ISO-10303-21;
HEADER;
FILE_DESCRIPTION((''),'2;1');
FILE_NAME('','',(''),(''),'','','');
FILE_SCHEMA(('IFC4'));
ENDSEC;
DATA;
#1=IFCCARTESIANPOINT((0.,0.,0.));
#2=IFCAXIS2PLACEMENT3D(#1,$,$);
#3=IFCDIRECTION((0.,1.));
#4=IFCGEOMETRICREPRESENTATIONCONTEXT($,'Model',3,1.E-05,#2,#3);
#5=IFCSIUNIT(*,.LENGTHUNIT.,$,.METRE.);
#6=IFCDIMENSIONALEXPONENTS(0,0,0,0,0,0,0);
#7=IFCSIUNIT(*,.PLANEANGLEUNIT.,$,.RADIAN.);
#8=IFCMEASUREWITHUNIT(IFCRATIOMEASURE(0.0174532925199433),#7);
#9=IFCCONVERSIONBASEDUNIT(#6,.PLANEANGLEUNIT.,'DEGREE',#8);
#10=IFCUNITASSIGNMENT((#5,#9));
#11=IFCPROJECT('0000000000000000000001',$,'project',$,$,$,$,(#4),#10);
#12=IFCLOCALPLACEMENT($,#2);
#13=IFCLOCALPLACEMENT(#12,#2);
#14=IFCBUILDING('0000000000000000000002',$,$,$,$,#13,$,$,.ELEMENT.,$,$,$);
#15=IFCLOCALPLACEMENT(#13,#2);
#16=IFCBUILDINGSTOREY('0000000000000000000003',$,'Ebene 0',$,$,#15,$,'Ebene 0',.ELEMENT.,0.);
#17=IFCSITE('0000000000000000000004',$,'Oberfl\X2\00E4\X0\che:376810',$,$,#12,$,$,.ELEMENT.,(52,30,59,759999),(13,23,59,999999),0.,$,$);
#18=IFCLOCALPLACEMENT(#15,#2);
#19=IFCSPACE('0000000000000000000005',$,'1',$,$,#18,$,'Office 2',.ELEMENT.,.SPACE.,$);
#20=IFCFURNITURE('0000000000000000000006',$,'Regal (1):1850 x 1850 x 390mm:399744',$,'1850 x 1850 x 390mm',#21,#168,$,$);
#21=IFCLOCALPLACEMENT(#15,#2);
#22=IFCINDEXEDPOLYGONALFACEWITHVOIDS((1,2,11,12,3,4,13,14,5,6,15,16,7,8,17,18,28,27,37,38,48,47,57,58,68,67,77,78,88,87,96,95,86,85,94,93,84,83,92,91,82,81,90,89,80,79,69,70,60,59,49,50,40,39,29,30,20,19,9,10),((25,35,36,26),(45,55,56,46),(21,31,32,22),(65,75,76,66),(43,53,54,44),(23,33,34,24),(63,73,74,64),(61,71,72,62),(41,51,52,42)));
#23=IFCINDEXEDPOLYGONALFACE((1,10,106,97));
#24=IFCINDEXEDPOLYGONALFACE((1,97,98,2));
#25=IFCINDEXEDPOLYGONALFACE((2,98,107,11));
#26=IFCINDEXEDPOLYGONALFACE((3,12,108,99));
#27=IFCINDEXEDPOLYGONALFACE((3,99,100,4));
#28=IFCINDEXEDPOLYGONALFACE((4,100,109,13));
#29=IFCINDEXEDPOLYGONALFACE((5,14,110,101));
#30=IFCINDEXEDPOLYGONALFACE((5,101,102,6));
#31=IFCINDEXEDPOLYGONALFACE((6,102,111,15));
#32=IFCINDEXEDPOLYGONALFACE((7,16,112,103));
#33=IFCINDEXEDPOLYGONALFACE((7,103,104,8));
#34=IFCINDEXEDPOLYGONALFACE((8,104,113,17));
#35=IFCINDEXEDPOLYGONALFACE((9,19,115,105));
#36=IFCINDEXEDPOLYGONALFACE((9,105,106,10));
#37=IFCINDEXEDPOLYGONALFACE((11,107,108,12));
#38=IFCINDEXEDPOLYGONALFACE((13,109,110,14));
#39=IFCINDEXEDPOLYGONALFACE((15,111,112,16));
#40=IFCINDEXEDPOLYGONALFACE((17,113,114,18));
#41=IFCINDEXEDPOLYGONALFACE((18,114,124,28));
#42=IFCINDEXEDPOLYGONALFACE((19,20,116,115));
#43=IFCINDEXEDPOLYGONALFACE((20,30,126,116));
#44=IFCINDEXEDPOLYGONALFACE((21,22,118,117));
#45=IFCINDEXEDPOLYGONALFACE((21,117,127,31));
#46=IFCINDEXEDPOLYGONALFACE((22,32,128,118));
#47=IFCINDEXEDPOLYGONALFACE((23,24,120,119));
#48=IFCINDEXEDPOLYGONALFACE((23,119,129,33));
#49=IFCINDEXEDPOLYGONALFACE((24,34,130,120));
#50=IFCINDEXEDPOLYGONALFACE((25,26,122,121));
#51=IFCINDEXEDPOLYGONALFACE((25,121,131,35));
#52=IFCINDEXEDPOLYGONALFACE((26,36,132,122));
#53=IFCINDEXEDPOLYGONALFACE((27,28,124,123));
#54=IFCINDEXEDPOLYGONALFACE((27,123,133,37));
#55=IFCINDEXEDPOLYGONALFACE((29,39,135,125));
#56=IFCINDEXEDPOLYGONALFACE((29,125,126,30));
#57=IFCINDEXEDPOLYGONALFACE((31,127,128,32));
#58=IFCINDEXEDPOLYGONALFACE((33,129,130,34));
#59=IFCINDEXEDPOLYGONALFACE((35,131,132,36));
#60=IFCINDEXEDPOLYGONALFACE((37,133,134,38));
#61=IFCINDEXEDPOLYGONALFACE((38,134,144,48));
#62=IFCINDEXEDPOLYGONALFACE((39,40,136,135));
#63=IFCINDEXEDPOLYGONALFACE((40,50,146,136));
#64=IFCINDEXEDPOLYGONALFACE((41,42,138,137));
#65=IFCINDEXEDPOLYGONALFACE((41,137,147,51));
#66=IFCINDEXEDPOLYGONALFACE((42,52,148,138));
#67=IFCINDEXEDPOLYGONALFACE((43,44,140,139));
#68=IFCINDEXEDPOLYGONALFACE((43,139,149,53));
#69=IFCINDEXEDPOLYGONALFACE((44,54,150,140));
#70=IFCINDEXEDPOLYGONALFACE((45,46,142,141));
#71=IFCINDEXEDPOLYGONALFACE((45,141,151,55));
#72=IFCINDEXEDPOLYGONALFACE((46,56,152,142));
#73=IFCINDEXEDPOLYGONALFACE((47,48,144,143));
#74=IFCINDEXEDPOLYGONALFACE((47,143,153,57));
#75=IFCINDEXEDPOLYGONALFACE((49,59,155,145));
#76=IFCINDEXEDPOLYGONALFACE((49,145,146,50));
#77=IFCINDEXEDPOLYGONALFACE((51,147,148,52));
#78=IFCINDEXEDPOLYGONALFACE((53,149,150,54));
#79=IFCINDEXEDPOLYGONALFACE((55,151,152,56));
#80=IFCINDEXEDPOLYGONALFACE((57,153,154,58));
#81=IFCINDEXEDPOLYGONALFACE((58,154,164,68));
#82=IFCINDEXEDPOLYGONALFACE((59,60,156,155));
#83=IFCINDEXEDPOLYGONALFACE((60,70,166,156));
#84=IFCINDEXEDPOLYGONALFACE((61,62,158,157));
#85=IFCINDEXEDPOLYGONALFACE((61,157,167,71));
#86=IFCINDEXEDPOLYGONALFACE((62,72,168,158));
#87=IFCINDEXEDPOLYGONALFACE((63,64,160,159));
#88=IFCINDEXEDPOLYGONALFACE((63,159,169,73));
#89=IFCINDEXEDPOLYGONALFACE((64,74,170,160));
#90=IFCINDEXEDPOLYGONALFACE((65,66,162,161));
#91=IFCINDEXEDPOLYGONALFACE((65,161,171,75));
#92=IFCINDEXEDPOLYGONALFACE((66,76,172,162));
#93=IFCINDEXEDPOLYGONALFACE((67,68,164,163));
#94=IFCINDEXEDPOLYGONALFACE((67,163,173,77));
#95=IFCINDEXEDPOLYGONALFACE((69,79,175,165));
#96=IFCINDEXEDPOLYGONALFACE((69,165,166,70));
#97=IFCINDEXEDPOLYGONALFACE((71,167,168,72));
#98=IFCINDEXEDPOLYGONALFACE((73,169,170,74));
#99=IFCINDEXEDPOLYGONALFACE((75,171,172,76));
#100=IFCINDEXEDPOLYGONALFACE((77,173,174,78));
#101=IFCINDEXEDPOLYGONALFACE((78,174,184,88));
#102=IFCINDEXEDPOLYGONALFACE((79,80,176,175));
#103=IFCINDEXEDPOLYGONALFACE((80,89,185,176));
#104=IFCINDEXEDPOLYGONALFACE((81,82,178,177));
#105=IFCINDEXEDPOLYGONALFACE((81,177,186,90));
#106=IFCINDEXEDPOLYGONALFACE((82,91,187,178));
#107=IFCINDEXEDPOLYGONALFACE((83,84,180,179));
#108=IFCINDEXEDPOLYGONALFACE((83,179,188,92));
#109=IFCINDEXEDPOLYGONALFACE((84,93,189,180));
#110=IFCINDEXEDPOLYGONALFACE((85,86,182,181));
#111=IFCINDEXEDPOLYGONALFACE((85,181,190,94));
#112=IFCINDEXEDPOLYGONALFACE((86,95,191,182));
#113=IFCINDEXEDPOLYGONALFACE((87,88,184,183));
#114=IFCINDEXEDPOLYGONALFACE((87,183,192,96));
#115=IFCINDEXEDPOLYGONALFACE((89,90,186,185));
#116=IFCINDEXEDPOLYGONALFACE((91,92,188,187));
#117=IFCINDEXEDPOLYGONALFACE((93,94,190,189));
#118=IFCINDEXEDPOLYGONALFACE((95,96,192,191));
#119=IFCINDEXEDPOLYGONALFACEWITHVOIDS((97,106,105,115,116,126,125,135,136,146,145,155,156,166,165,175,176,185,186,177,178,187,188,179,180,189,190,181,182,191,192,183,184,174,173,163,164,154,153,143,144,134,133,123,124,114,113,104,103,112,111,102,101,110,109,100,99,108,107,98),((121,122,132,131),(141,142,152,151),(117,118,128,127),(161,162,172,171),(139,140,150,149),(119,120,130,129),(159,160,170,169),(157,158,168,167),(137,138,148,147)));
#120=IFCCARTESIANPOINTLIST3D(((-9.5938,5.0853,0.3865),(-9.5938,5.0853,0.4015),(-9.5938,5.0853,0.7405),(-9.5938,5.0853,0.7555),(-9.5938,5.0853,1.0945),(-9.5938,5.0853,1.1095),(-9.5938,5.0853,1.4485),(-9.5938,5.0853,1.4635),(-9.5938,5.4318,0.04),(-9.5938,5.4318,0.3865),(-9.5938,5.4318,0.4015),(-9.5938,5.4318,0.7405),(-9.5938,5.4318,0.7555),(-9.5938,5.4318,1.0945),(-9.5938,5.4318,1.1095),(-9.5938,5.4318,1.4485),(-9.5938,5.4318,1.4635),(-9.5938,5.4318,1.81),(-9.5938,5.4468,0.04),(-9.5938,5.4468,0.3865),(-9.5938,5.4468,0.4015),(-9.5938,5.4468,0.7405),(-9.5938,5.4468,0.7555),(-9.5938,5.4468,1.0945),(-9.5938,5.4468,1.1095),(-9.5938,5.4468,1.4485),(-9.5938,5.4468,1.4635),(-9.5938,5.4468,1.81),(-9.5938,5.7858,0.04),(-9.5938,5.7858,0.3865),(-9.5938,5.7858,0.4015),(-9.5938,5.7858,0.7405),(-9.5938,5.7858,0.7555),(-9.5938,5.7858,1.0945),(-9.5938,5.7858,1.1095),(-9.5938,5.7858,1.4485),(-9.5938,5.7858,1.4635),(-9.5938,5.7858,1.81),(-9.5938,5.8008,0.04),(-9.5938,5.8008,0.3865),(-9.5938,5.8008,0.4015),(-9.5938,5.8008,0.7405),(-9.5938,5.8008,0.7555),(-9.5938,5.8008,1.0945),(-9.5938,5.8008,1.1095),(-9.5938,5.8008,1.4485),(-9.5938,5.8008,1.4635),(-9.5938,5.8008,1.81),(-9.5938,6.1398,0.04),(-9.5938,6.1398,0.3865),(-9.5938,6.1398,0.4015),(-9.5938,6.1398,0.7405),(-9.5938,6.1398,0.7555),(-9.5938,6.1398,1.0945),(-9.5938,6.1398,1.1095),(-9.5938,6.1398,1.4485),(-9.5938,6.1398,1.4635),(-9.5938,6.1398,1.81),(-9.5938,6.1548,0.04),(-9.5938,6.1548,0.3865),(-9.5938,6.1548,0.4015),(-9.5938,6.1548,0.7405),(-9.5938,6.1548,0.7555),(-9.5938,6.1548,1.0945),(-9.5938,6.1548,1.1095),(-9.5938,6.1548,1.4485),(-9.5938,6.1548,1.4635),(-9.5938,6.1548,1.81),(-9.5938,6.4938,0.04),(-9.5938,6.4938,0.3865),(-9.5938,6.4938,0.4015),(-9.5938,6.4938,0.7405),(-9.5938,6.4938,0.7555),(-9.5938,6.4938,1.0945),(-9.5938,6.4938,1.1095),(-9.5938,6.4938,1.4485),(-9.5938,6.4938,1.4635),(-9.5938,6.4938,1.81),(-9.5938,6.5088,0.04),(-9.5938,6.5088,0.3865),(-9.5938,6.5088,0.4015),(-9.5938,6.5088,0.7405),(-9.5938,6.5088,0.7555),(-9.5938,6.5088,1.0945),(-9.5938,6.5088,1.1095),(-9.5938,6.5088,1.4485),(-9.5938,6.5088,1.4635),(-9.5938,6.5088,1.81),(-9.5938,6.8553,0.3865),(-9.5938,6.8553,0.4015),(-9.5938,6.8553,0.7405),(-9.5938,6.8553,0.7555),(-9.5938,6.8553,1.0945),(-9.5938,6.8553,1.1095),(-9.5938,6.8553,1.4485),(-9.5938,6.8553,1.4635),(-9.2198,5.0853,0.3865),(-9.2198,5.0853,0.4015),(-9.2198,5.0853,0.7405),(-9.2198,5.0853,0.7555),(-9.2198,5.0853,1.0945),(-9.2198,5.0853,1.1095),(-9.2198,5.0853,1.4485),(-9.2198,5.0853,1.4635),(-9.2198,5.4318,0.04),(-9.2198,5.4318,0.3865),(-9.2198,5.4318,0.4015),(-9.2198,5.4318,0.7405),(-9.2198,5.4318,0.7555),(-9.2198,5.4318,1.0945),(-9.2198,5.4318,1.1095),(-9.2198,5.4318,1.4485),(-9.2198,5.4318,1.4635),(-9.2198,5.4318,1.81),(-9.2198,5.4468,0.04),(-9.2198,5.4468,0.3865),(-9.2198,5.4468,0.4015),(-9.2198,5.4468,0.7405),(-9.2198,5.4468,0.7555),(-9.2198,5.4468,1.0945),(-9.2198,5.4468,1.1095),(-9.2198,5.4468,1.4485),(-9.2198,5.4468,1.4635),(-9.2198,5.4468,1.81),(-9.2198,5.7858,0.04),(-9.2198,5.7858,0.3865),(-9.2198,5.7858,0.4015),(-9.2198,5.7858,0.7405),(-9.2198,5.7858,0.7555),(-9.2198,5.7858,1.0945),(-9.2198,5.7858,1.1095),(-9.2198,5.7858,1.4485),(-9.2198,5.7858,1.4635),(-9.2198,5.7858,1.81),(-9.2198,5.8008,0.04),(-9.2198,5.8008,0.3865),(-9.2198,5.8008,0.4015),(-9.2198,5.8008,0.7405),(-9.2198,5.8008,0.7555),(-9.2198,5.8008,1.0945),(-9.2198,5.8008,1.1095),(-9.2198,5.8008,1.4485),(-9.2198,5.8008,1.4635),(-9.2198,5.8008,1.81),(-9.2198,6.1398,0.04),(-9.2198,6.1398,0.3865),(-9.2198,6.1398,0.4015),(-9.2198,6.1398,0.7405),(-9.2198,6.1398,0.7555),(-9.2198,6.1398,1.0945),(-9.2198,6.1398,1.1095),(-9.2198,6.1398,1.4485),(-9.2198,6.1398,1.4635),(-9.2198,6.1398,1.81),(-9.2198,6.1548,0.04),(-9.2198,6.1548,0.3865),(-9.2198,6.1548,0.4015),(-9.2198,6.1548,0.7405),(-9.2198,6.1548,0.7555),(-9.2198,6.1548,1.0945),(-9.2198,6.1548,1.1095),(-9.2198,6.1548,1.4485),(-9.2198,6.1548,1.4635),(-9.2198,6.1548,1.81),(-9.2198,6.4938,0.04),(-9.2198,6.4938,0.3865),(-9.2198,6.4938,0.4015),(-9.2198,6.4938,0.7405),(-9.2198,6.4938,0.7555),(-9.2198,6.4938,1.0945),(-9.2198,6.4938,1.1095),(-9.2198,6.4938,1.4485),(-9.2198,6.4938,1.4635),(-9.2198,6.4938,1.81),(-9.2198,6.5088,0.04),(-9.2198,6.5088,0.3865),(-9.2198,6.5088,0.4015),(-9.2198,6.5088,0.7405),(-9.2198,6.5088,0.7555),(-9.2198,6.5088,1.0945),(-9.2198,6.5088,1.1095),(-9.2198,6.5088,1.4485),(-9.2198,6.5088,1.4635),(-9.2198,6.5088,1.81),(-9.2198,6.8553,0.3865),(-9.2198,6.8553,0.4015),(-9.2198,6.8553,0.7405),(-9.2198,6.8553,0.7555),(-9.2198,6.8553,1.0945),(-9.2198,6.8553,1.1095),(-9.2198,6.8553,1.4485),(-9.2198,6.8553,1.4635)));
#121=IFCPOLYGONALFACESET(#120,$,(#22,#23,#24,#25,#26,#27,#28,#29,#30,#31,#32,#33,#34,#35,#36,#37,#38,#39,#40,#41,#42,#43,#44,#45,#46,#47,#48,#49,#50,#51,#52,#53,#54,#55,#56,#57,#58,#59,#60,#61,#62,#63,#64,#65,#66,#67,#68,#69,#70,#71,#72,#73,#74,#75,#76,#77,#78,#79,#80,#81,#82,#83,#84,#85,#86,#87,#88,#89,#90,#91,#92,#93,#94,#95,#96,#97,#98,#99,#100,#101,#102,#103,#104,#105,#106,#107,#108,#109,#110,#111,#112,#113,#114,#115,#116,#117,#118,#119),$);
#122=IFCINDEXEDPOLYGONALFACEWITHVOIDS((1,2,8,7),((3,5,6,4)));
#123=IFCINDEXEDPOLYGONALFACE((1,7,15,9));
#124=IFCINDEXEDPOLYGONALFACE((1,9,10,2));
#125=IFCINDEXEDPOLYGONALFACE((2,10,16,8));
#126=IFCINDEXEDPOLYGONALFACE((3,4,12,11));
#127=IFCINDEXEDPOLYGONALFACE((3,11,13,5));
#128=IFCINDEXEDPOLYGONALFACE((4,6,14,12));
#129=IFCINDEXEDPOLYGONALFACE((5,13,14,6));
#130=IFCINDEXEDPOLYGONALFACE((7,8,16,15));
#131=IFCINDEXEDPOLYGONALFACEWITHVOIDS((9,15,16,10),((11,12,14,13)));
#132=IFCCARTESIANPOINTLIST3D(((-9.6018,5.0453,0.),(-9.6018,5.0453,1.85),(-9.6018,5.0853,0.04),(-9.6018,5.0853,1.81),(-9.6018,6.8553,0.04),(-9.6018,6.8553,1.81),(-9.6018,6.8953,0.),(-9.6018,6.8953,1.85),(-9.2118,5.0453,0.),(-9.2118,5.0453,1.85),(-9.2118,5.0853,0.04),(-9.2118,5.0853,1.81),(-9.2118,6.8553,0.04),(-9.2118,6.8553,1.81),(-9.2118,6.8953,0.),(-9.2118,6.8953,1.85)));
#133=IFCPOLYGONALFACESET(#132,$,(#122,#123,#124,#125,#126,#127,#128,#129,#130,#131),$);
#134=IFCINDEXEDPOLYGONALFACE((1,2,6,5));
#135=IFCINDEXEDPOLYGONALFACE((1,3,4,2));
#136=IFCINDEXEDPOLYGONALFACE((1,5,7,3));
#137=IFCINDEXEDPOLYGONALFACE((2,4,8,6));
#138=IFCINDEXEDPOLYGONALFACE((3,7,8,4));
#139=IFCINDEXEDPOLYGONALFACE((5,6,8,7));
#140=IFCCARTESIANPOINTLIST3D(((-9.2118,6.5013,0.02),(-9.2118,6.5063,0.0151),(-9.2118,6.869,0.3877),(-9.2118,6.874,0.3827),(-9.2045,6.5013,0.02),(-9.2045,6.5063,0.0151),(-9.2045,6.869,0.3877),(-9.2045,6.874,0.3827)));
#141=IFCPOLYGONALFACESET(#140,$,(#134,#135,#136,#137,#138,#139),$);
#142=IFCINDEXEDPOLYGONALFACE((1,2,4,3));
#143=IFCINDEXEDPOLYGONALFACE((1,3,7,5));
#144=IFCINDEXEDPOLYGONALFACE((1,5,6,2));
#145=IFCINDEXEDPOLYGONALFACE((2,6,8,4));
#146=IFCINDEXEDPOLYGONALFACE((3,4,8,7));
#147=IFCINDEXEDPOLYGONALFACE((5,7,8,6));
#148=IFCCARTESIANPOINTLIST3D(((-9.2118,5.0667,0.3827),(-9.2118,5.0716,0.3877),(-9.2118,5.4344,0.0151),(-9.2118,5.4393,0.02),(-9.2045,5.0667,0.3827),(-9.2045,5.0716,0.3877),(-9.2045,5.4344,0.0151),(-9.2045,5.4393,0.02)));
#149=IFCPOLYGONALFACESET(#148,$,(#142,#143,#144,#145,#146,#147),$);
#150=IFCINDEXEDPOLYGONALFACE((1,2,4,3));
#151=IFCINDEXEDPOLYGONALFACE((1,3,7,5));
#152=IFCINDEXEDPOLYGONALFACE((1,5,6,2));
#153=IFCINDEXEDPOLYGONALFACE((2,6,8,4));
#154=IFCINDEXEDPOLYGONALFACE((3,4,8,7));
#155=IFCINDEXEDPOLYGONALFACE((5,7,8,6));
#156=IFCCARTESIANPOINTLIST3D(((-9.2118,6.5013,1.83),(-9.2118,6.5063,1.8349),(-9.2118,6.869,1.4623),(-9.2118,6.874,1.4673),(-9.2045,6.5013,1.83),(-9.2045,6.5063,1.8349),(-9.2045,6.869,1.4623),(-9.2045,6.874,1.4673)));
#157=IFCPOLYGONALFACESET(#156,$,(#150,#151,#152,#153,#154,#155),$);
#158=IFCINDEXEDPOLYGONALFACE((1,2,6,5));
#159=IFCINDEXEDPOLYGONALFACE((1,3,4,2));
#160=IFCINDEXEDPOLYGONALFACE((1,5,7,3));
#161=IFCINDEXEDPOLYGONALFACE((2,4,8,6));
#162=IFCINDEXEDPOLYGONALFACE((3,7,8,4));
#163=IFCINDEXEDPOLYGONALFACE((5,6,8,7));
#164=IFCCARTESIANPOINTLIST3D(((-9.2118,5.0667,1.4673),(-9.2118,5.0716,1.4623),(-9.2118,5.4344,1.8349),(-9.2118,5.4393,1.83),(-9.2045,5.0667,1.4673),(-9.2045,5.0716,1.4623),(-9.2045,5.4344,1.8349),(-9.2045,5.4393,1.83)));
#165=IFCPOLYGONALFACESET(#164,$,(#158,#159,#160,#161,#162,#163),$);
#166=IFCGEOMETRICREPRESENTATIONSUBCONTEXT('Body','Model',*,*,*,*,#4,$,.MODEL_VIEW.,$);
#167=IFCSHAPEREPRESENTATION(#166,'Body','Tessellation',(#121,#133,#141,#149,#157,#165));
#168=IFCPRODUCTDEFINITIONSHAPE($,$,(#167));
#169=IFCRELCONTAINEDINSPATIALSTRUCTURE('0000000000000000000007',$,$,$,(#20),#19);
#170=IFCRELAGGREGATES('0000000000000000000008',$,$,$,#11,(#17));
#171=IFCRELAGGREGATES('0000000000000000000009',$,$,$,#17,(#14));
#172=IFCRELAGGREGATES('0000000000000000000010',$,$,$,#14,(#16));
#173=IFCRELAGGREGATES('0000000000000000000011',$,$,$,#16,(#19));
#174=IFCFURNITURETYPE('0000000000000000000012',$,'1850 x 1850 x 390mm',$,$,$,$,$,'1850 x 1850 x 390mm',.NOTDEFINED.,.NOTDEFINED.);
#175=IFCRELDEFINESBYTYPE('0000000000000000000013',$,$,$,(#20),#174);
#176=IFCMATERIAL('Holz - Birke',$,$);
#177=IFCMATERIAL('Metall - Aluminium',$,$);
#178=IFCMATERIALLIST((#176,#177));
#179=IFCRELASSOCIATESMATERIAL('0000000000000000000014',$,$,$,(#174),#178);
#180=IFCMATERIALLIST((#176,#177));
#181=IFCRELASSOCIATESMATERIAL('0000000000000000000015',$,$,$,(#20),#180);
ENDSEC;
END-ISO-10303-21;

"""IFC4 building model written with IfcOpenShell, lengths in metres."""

from ifc_helpers import new_model, entity, si_unit, converted_unit, direction, frame, frame_2d, origin, place, context, subcontext, project, spatial, polyline, rectangle, outline, extrude, source, transform, mapped, material, material_list, type_object, type_shapes, element, save


model = new_model("IFC4")

# Units and contexts
model_context = context("Model", 3, precision=1e-05, world=origin(), true_north=direction((0.0, 1.0)))
body_context = subcontext(model_context, "Body", "Model", "MODEL_VIEW")
ifc_project = project(units=[si_unit("LENGTHUNIT", "METRE"), converted_unit("PLANEANGLEUNIT", "DEGREE", entity("IfcRatioMeasure", 0.0174532925199433), si_unit("PLANEANGLEUNIT", "RADIAN"), dimensions=[0, 0, 0, 0, 0, 0, 0])], contexts=[model_context])

# Site, building, storey
site_placement = place(None, origin())
site = spatial("IfcSite", under=ifc_project, at=site_placement, Name="Oberfläche:376810", CompositionType="ELEMENT", RefLatitude=(52, 30, 59, 759999), RefLongitude=(13, 23, 59, 999999), RefElevation=0.0)
building_placement = place(site_placement, origin())
building = spatial("IfcBuilding", under=site, at=building_placement, CompositionType="ELEMENT")
storey_placement = place(building_placement, origin())
storey = spatial("IfcBuildingStorey", under=building, at=storey_placement, Name="Ebene 0", LongName="Ebene 0", CompositionType="ELEMENT", Elevation=0.0)

# Shared definitions
space_placement = place(storey_placement, origin())
space = spatial("IfcSpace", under=storey, at=space_placement, Name="1", LongName="Office 2", CompositionType="ELEMENT", PredefinedType="SPACE")

# Furniture
ifc_material_1 = material(Name="Holz - Birke")
ifc_material_2 = material(Name="Metall - Aluminium")
ifc_material_list_1 = material_list([ifc_material_1, ifc_material_2])
ifc_material_list_2 = material_list([ifc_material_1, ifc_material_2])
furniture_type_1 = type_object("IfcFurnitureType", Name="1850 x 1850 x 390mm", ElementType="1850 x 1850 x 390mm", AssemblyPlace="NOTDEFINED", PredefinedType="NOTDEFINED", material=ifc_material_list_2)
shared_shape_1 = source(origin(), body_context, "Body", "SweptSolid", [
    extrude(outline(polyline([(0.5385, -0.5385), (0.885, -0.5385), (0.885, -0.5235), (0.5385, -0.5235), (0.5385, -0.1845), (0.885, -0.1845), (0.885, -0.1695), (0.5385, -0.1695), (0.5385, 0.1695), (0.885, 0.1695), (0.885, 0.1845), (0.5385, 0.1845), (0.5385, 0.5235), (0.885, 0.5235), (0.885, 0.5385), (0.5385, 0.5385), (0.5385, 0.885), (0.5235, 0.885), (0.5235, 0.5385), (0.1845, 0.5385), (0.1845, 0.885), (0.1695, 0.885), (0.1695, 0.5385), (-0.1695, 0.5385), (-0.1695, 0.885), (-0.1845, 0.885), (-0.1845, 0.5385), (-0.5235, 0.5385), (-0.5235, 0.885), (-0.5385, 0.885), (-0.5385, 0.5385), (-0.885, 0.5385), (-0.885, 0.5235), (-0.5385, 0.5235), (-0.5385, 0.1845), (-0.885, 0.1845), (-0.885, 0.1695), (-0.5385, 0.1695), (-0.5385, -0.1695), (-0.885, -0.1695), (-0.885, -0.1845), (-0.5385, -0.1845), (-0.5385, -0.5235), (-0.885, -0.5235), (-0.885, -0.5385), (-0.5385, -0.5385), (-0.5385, -0.885), (-0.5235, -0.885), (-0.5235, -0.5385), (-0.1845, -0.5385), (-0.1845, -0.885), (-0.1695, -0.885), (-0.1695, -0.5385), (0.1695, -0.5385), (0.1695, -0.885), (0.1845, -0.885), (0.1845, -0.5385), (0.5235, -0.5385), (0.5235, -0.885), (0.5385, -0.885), (0.5385, -0.5385)]), holes=[polyline([(0.5235, -0.1845), (0.5235, -0.5235), (0.1845, -0.5235), (0.1845, -0.1845), (0.5235, -0.1845)]), polyline([(0.1845, -0.1695), (0.1845, 0.1695), (0.5235, 0.1695), (0.5235, -0.1695), (0.1845, -0.1695)]), polyline([(0.1845, 0.1845), (0.1845, 0.5235), (0.5235, 0.5235), (0.5235, 0.1845), (0.1845, 0.1845)]), polyline([(-0.1695, 0.5235), (0.1695, 0.5235), (0.1695, 0.1845), (-0.1695, 0.1845), (-0.1695, 0.5235)]), polyline([(-0.1695, 0.1695), (0.1695, 0.1695), (0.1695, -0.1695), (-0.1695, -0.1695), (-0.1695, 0.1695)]), polyline([(-0.1695, -0.1845), (0.1695, -0.1845), (0.1695, -0.5235), (-0.1695, -0.5235), (-0.1695, -0.1845)]), polyline([(-0.5235, -0.5235), (-0.5235, -0.1845), (-0.1845, -0.1845), (-0.1845, -0.5235), (-0.5235, -0.5235)]), polyline([(-0.5235, -0.1695), (-0.5235, 0.1695), (-0.1845, 0.1695), (-0.1845, -0.1695), (-0.5235, -0.1695)]), polyline([(-0.5235, 0.1845), (-0.5235, 0.5235), (-0.1845, 0.5235), (-0.1845, 0.1845), (-0.5235, 0.1845)])]), frame((0.2471, -0.2571, 0.925), z_axis=(0.0, 1.0, 0.0), x_axis=(0.0, 0.0, 1.0)), (0.0, 0.0, 1.0), 0.374),
    extrude(outline(polyline([(-0.925, -0.925), (0.925, -0.925), (0.925, 0.925), (-0.925, 0.925), (-0.925, -0.925)]), holes=[polyline([(-0.885, -0.885), (-0.885, 0.885), (0.885, 0.885), (0.885, -0.885), (-0.885, -0.885)])]), frame((0.2471, -0.2651, 0.925), z_axis=(0.0, 1.0, 0.0), x_axis=(0.0, 0.0, -1.0)), (0.0, 0.0, 1.0), 0.39),
    extrude(rectangle(XDim=0.007, YDim=0.0073, at=frame_2d((0.0, 0.0), x_axis=(0.0, 1.0))), frame((-0.2864, 0.1286, 0.0175), z_axis=(-0.707107, 0.0, 0.707107), x_axis=(0.0, 1.0, 0.0)), (0.0, 0.0, 1.0), 0.52),
    extrude(rectangle(XDim=0.007, YDim=0.0073, at=frame_2d((0.0, 0.0), x_axis=(0.0, 1.0))), frame((0.7805, 0.1286, 0.0175), z_axis=(0.707107, 0.0, 0.707107), x_axis=(0.0, 1.0, 0.0)), (0.0, 0.0, 1.0), 0.52),
    extrude(rectangle(XDim=0.007, YDim=0.0073, at=frame_2d((0.0, 0.0), x_axis=(0.0, 1.0))), frame((-0.6541, 0.1286, 1.4648), z_axis=(0.707107, 0.0, 0.707107), x_axis=(0.0, 1.0, 0.0)), (0.0, 0.0, 1.0), 0.52),
    extrude(rectangle(XDim=0.007, YDim=0.0073, at=frame_2d((0.0, 0.0), x_axis=(0.0, 1.0))), frame((1.1482, 0.1286, 1.4648), z_axis=(-0.707107, 0.0, 0.707107), x_axis=(0.0, 1.0, 0.0)), (0.0, 0.0, 1.0), 0.52),
])
type_shapes(furniture_type_1, [shared_shape_1])
furniture_1_placement = place(space_placement, frame((-9.3367, 6.2174, 0.0), z_axis=(0.0, 0.0, 1.0), x_axis=(0.0, -1.0, 0.0)))
element("IfcFurniture", 1, at=furniture_1_placement, inside=space, type_object=furniture_type_1, material=ifc_material_list_1, Name="Regal (1):1850 x 1850 x 390mm:399744", ObjectType="1850 x 1850 x 390mm", context=body_context, shape_type="MappedRepresentation", body=[
    mapped(shared_shape_1, transform((0.0, 0.0, 0.0), scale=1.0)),
])

save(model, "model.ifc")
